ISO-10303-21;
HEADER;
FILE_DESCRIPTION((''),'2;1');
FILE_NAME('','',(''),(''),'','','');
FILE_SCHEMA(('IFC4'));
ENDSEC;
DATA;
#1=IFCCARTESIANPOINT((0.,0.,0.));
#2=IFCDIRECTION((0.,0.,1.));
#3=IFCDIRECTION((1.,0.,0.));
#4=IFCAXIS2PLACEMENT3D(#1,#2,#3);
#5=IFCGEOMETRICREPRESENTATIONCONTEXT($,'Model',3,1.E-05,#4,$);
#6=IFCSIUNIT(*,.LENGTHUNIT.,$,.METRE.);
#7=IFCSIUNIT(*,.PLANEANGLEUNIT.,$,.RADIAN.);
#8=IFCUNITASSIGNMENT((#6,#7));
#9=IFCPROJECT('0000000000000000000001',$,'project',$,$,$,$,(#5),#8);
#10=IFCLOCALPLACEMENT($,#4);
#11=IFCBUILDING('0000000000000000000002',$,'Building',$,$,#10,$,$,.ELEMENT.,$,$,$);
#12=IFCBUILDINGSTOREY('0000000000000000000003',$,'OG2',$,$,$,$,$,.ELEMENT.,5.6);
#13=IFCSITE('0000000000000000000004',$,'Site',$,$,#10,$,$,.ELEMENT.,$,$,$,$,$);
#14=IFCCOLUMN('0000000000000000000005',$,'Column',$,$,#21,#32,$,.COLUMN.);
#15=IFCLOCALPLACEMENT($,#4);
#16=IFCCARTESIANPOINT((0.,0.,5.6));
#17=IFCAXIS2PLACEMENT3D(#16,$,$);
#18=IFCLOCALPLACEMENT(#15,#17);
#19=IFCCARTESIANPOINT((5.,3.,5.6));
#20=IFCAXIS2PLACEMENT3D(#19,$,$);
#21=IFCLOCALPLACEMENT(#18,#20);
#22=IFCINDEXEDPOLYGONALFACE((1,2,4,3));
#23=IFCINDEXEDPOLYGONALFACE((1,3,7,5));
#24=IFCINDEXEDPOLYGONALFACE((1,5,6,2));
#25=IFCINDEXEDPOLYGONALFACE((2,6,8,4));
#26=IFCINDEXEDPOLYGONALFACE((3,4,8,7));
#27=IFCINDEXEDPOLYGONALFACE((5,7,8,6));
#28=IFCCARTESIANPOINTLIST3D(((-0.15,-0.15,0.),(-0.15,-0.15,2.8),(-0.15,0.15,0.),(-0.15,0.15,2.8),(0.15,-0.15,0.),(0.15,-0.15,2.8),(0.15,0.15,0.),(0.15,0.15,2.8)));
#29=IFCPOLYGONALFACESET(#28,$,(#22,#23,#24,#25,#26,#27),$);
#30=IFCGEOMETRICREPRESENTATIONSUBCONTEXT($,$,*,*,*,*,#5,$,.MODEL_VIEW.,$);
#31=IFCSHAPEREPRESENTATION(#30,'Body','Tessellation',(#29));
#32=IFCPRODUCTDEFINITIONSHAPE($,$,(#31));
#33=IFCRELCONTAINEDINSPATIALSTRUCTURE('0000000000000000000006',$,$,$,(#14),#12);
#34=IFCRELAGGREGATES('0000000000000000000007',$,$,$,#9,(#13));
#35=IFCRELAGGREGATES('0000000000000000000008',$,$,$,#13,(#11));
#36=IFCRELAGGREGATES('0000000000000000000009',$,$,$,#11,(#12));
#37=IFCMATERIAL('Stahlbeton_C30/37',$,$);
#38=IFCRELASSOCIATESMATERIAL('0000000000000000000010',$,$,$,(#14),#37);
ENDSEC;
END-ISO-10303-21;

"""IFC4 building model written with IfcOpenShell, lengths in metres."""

from ifc_helpers import new_model, si_unit, frame, origin, origin_with_axes, origin_2d, place, context, subcontext, project, spatial, rectangle, extrude, material, element, save


model = new_model("IFC4")

# Units and contexts
model_context = context("Model", 3, precision=1e-05, world=origin_with_axes())
sub_context = subcontext(model_context, None, None, "MODEL_VIEW")
ifc_project = project(units=[si_unit("LENGTHUNIT", "METRE"), si_unit("PLANEANGLEUNIT", "RADIAN")], contexts=[model_context])

# Site, building, storey
placement_1 = place(None, origin_with_axes())
site = spatial("IfcSite", under=ifc_project, at=placement_1, Name="Site", CompositionType="ELEMENT")
building = spatial("IfcBuilding", under=site, at=placement_1, Name="Building", CompositionType="ELEMENT")
storey = spatial("IfcBuildingStorey", under=building, Name="OG2", CompositionType="ELEMENT", Elevation=5.6)

# Column
ifc_material = material(Name="Stahlbeton_C30/37")
placement_2 = place(None, origin_with_axes())
placement_3 = place(placement_2, frame((0.0, 0.0, 5.6)))
column_placement = place(placement_3, frame((5.0, 3.0, 5.6)))
element("IfcColumn", 1, at=column_placement, inside=storey, material=ifc_material, Name="Column", PredefinedType="COLUMN", context=sub_context, shape_type="SweptSolid", body=[
    extrude(rectangle(XDim=0.3, YDim=0.3, at=origin_2d()), origin(), (0.0, 0.0, 1.0), 2.8),
])

save(model, "model.ifc")
